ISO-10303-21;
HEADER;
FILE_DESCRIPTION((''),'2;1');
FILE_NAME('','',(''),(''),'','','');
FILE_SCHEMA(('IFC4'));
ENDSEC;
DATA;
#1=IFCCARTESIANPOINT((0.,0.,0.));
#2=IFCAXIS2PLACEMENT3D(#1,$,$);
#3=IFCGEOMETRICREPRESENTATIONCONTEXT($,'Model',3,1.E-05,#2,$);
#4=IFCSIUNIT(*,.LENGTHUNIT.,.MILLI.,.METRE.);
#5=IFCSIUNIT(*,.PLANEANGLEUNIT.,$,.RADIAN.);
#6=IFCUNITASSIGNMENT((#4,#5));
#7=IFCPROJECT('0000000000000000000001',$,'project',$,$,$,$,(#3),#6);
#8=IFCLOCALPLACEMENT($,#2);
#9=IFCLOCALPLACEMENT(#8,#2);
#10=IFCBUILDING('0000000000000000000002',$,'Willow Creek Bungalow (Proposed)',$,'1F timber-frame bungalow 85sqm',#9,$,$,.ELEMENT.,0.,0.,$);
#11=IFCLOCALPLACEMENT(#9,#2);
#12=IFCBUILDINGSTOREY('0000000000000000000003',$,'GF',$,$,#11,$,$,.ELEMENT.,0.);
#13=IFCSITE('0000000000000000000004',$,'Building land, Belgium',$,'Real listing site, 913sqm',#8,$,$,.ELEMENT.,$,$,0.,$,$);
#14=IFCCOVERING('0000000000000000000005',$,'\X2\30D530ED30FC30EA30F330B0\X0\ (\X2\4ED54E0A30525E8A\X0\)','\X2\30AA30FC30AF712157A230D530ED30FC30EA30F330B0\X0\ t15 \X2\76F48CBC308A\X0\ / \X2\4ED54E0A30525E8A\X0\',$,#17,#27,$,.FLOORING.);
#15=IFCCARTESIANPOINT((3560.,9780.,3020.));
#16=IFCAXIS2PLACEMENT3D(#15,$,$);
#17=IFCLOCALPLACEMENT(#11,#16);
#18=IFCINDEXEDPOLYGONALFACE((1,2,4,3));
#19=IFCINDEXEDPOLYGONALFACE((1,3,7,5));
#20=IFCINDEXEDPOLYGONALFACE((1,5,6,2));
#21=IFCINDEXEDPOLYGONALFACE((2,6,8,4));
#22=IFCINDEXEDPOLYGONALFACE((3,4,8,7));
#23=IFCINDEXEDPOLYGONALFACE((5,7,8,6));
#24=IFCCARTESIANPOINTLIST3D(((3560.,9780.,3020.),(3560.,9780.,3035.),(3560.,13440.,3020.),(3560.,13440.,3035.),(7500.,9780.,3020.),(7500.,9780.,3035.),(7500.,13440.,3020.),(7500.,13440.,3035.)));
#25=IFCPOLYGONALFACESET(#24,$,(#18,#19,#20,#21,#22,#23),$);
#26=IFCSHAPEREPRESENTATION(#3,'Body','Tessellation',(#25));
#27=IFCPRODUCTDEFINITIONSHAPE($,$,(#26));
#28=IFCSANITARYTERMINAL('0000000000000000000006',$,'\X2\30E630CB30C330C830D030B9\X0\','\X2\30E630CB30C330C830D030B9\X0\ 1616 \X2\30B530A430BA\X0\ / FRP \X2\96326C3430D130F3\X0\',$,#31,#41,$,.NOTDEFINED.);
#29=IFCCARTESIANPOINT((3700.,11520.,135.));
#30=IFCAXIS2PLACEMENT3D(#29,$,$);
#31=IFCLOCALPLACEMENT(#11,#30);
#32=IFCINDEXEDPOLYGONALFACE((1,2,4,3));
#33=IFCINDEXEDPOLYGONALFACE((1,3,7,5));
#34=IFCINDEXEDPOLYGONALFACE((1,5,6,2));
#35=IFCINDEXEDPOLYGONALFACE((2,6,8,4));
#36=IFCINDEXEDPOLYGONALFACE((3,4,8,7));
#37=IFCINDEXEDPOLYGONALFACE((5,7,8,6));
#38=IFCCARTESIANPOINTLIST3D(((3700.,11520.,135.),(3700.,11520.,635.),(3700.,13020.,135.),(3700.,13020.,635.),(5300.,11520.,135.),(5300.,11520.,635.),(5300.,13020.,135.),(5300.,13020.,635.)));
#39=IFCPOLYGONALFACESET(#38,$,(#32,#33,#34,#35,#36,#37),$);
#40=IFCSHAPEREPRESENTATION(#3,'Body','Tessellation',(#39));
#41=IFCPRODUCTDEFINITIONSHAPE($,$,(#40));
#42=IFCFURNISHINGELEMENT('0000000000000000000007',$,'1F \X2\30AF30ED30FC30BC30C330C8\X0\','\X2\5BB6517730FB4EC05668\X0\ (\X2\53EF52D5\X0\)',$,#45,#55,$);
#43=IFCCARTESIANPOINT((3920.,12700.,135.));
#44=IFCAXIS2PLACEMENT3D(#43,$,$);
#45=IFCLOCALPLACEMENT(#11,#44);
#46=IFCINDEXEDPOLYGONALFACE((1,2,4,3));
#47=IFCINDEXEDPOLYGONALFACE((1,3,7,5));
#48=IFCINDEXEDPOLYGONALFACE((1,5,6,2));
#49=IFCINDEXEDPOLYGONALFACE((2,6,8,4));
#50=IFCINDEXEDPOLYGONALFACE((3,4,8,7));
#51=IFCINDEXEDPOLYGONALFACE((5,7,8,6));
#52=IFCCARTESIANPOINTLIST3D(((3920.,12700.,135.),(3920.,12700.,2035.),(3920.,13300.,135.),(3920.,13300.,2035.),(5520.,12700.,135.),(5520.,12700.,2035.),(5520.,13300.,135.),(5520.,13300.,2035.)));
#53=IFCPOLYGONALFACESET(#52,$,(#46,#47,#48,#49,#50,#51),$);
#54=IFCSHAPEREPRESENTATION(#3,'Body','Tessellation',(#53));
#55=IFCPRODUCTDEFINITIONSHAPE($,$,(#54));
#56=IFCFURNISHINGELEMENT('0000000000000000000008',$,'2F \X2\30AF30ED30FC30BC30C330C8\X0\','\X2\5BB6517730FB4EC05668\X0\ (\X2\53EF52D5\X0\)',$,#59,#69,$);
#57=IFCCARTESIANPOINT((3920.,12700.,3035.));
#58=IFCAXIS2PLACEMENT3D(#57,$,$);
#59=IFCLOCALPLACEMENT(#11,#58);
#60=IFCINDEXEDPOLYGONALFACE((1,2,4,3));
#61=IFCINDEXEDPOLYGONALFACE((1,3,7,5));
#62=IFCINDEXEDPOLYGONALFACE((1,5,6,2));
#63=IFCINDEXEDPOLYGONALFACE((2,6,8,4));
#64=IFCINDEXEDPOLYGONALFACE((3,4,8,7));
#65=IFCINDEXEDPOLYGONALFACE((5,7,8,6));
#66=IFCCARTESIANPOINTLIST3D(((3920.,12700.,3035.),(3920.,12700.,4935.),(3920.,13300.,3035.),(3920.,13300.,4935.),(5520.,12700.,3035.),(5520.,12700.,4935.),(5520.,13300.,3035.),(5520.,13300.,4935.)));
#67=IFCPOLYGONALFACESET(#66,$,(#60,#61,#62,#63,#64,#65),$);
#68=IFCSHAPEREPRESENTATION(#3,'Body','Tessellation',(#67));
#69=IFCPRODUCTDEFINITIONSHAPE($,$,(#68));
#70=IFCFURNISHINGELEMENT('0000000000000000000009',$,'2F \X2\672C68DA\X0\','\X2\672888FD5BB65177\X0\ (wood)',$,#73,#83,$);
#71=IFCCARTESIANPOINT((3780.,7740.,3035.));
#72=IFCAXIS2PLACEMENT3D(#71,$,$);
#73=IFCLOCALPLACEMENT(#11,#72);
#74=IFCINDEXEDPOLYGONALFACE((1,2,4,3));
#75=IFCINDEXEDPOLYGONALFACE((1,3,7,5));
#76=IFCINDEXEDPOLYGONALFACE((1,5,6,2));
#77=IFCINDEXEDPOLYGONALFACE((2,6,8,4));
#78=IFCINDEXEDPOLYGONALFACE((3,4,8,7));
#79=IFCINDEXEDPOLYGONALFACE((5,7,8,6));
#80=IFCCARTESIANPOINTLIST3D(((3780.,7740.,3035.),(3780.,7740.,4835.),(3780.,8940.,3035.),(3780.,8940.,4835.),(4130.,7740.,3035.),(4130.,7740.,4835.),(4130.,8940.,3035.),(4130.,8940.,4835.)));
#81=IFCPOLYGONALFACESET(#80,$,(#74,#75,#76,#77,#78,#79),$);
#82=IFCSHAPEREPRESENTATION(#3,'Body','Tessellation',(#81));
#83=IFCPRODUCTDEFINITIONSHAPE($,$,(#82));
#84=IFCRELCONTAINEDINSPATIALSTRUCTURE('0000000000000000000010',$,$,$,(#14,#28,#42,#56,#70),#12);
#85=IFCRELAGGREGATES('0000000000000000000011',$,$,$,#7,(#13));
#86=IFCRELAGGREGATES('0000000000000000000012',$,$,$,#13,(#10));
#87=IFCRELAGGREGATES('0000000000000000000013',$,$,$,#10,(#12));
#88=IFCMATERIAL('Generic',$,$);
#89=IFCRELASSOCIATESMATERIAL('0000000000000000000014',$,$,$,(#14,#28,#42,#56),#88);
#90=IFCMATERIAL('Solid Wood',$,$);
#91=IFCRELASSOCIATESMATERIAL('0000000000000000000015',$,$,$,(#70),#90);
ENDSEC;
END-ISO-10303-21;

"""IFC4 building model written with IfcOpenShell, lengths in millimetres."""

from ifc_helpers import new_model, si_unit, frame, frame_2d, origin, place, context, project, spatial, rectangle, extrude, material, element, save


model = new_model("IFC4")

# Units and contexts
model_context = context("Model", 3, precision=1e-05, world=origin())
ifc_project = project(units=[si_unit("LENGTHUNIT", "METRE", prefix="MILLI"), si_unit("PLANEANGLEUNIT", "RADIAN")], contexts=[model_context])

# Site, building, storey
site_placement = place(None, origin())
site = spatial("IfcSite", under=ifc_project, at=site_placement, Name="Building land, Belgium", ObjectType="Real listing site, 913sqm", CompositionType="ELEMENT", RefElevation=0.0)
building_placement = place(site_placement, origin())
building = spatial("IfcBuilding", under=site, at=building_placement, Name="Willow Creek Bungalow (Proposed)", ObjectType="1F timber-frame bungalow 85sqm", CompositionType="ELEMENT", ElevationOfRefHeight=0.0, ElevationOfTerrain=0.0)
storey_placement = place(building_placement, origin())
storey = spatial("IfcBuildingStorey", under=building, at=storey_placement, Name="GF", CompositionType="ELEMENT", Elevation=0.0)

# Shared definitions
ifc_material_1 = material(Name="Solid Wood")

# Covering
ifc_material_2 = material(Name="Generic")
covering_1_placement = place(storey_placement, frame((3560.0, 9780.0, 3020.0)))
element("IfcCovering", 1, at=covering_1_placement, inside=storey, material=ifc_material_2, Name="フローリング (仕上げ床)", Description="オーク無垢フローリング t15 直貼り / 仕上げ床", PredefinedType="FLOORING", context=model_context, shape_type="SweptSolid", body=[
    extrude(rectangle(XDim=3940.0, YDim=3660.0, at=frame_2d((1970.0, 1830.0))), frame((3560.0, 9780.0, 3020.0)), (0.0, 0.0, 1.0), 15.0),
])

# Sanitary terminal
sanitary_terminal_placement = place(storey_placement, frame((3700.0, 11520.0, 135.0)))
element("IfcSanitaryTerminal", 2, at=sanitary_terminal_placement, inside=storey, material=ifc_material_2, Name="ユニットバス", Description="ユニットバス 1616 サイズ / FRP 防水パン", PredefinedType="NOTDEFINED", context=model_context, shape_type="SweptSolid", body=[
    extrude(rectangle(XDim=1600.0, YDim=1500.0, at=frame_2d((800.0, 750.0))), frame((3700.0, 11520.0, 135.0)), (0.0, 0.0, 1.0), 500.0),
])

# Furnishing elements
furnishing_1_placement = place(storey_placement, frame((3920.0, 12700.0, 135.0)))
element("IfcFurnishingElement", 3, at=furnishing_1_placement, inside=storey, material=ifc_material_2, Name="1F クローゼット", Description="家具・什器 (可動)", context=model_context, shape_type="SweptSolid", body=[
    extrude(rectangle(XDim=1600.0, YDim=600.0, at=frame_2d((800.0, 300.0))), frame((3920.0, 12700.0, 135.0)), (0.0, 0.0, 1.0), 1900.0),
])
furnishing_2_placement = place(storey_placement, frame((3920.0, 12700.0, 3035.0)))
element("IfcFurnishingElement", 4, at=furnishing_2_placement, inside=storey, material=ifc_material_2, Name="2F クローゼット", Description="家具・什器 (可動)", context=model_context, shape_type="SweptSolid", body=[
    extrude(rectangle(XDim=1600.0, YDim=600.0, at=frame_2d((800.0, 300.0))), frame((3920.0, 12700.0, 3035.0)), (0.0, 0.0, 1.0), 1900.0),
])
furnishing_3_placement = place(storey_placement, frame((3780.0, 7740.0, 3035.0)))
element("IfcFurnishingElement", 5, at=furnishing_3_placement, inside=storey, material=ifc_material_1, Name="2F 本棚", Description="木製家具 (wood)", context=model_context, shape_type="SweptSolid", body=[
    extrude(rectangle(XDim=350.0, YDim=1200.0, at=frame_2d((175.0, 600.0))), frame((3780.0, 7740.0, 3035.0)), (0.0, 0.0, 1.0), 1800.0),
])

save(model, "model.ifc")
